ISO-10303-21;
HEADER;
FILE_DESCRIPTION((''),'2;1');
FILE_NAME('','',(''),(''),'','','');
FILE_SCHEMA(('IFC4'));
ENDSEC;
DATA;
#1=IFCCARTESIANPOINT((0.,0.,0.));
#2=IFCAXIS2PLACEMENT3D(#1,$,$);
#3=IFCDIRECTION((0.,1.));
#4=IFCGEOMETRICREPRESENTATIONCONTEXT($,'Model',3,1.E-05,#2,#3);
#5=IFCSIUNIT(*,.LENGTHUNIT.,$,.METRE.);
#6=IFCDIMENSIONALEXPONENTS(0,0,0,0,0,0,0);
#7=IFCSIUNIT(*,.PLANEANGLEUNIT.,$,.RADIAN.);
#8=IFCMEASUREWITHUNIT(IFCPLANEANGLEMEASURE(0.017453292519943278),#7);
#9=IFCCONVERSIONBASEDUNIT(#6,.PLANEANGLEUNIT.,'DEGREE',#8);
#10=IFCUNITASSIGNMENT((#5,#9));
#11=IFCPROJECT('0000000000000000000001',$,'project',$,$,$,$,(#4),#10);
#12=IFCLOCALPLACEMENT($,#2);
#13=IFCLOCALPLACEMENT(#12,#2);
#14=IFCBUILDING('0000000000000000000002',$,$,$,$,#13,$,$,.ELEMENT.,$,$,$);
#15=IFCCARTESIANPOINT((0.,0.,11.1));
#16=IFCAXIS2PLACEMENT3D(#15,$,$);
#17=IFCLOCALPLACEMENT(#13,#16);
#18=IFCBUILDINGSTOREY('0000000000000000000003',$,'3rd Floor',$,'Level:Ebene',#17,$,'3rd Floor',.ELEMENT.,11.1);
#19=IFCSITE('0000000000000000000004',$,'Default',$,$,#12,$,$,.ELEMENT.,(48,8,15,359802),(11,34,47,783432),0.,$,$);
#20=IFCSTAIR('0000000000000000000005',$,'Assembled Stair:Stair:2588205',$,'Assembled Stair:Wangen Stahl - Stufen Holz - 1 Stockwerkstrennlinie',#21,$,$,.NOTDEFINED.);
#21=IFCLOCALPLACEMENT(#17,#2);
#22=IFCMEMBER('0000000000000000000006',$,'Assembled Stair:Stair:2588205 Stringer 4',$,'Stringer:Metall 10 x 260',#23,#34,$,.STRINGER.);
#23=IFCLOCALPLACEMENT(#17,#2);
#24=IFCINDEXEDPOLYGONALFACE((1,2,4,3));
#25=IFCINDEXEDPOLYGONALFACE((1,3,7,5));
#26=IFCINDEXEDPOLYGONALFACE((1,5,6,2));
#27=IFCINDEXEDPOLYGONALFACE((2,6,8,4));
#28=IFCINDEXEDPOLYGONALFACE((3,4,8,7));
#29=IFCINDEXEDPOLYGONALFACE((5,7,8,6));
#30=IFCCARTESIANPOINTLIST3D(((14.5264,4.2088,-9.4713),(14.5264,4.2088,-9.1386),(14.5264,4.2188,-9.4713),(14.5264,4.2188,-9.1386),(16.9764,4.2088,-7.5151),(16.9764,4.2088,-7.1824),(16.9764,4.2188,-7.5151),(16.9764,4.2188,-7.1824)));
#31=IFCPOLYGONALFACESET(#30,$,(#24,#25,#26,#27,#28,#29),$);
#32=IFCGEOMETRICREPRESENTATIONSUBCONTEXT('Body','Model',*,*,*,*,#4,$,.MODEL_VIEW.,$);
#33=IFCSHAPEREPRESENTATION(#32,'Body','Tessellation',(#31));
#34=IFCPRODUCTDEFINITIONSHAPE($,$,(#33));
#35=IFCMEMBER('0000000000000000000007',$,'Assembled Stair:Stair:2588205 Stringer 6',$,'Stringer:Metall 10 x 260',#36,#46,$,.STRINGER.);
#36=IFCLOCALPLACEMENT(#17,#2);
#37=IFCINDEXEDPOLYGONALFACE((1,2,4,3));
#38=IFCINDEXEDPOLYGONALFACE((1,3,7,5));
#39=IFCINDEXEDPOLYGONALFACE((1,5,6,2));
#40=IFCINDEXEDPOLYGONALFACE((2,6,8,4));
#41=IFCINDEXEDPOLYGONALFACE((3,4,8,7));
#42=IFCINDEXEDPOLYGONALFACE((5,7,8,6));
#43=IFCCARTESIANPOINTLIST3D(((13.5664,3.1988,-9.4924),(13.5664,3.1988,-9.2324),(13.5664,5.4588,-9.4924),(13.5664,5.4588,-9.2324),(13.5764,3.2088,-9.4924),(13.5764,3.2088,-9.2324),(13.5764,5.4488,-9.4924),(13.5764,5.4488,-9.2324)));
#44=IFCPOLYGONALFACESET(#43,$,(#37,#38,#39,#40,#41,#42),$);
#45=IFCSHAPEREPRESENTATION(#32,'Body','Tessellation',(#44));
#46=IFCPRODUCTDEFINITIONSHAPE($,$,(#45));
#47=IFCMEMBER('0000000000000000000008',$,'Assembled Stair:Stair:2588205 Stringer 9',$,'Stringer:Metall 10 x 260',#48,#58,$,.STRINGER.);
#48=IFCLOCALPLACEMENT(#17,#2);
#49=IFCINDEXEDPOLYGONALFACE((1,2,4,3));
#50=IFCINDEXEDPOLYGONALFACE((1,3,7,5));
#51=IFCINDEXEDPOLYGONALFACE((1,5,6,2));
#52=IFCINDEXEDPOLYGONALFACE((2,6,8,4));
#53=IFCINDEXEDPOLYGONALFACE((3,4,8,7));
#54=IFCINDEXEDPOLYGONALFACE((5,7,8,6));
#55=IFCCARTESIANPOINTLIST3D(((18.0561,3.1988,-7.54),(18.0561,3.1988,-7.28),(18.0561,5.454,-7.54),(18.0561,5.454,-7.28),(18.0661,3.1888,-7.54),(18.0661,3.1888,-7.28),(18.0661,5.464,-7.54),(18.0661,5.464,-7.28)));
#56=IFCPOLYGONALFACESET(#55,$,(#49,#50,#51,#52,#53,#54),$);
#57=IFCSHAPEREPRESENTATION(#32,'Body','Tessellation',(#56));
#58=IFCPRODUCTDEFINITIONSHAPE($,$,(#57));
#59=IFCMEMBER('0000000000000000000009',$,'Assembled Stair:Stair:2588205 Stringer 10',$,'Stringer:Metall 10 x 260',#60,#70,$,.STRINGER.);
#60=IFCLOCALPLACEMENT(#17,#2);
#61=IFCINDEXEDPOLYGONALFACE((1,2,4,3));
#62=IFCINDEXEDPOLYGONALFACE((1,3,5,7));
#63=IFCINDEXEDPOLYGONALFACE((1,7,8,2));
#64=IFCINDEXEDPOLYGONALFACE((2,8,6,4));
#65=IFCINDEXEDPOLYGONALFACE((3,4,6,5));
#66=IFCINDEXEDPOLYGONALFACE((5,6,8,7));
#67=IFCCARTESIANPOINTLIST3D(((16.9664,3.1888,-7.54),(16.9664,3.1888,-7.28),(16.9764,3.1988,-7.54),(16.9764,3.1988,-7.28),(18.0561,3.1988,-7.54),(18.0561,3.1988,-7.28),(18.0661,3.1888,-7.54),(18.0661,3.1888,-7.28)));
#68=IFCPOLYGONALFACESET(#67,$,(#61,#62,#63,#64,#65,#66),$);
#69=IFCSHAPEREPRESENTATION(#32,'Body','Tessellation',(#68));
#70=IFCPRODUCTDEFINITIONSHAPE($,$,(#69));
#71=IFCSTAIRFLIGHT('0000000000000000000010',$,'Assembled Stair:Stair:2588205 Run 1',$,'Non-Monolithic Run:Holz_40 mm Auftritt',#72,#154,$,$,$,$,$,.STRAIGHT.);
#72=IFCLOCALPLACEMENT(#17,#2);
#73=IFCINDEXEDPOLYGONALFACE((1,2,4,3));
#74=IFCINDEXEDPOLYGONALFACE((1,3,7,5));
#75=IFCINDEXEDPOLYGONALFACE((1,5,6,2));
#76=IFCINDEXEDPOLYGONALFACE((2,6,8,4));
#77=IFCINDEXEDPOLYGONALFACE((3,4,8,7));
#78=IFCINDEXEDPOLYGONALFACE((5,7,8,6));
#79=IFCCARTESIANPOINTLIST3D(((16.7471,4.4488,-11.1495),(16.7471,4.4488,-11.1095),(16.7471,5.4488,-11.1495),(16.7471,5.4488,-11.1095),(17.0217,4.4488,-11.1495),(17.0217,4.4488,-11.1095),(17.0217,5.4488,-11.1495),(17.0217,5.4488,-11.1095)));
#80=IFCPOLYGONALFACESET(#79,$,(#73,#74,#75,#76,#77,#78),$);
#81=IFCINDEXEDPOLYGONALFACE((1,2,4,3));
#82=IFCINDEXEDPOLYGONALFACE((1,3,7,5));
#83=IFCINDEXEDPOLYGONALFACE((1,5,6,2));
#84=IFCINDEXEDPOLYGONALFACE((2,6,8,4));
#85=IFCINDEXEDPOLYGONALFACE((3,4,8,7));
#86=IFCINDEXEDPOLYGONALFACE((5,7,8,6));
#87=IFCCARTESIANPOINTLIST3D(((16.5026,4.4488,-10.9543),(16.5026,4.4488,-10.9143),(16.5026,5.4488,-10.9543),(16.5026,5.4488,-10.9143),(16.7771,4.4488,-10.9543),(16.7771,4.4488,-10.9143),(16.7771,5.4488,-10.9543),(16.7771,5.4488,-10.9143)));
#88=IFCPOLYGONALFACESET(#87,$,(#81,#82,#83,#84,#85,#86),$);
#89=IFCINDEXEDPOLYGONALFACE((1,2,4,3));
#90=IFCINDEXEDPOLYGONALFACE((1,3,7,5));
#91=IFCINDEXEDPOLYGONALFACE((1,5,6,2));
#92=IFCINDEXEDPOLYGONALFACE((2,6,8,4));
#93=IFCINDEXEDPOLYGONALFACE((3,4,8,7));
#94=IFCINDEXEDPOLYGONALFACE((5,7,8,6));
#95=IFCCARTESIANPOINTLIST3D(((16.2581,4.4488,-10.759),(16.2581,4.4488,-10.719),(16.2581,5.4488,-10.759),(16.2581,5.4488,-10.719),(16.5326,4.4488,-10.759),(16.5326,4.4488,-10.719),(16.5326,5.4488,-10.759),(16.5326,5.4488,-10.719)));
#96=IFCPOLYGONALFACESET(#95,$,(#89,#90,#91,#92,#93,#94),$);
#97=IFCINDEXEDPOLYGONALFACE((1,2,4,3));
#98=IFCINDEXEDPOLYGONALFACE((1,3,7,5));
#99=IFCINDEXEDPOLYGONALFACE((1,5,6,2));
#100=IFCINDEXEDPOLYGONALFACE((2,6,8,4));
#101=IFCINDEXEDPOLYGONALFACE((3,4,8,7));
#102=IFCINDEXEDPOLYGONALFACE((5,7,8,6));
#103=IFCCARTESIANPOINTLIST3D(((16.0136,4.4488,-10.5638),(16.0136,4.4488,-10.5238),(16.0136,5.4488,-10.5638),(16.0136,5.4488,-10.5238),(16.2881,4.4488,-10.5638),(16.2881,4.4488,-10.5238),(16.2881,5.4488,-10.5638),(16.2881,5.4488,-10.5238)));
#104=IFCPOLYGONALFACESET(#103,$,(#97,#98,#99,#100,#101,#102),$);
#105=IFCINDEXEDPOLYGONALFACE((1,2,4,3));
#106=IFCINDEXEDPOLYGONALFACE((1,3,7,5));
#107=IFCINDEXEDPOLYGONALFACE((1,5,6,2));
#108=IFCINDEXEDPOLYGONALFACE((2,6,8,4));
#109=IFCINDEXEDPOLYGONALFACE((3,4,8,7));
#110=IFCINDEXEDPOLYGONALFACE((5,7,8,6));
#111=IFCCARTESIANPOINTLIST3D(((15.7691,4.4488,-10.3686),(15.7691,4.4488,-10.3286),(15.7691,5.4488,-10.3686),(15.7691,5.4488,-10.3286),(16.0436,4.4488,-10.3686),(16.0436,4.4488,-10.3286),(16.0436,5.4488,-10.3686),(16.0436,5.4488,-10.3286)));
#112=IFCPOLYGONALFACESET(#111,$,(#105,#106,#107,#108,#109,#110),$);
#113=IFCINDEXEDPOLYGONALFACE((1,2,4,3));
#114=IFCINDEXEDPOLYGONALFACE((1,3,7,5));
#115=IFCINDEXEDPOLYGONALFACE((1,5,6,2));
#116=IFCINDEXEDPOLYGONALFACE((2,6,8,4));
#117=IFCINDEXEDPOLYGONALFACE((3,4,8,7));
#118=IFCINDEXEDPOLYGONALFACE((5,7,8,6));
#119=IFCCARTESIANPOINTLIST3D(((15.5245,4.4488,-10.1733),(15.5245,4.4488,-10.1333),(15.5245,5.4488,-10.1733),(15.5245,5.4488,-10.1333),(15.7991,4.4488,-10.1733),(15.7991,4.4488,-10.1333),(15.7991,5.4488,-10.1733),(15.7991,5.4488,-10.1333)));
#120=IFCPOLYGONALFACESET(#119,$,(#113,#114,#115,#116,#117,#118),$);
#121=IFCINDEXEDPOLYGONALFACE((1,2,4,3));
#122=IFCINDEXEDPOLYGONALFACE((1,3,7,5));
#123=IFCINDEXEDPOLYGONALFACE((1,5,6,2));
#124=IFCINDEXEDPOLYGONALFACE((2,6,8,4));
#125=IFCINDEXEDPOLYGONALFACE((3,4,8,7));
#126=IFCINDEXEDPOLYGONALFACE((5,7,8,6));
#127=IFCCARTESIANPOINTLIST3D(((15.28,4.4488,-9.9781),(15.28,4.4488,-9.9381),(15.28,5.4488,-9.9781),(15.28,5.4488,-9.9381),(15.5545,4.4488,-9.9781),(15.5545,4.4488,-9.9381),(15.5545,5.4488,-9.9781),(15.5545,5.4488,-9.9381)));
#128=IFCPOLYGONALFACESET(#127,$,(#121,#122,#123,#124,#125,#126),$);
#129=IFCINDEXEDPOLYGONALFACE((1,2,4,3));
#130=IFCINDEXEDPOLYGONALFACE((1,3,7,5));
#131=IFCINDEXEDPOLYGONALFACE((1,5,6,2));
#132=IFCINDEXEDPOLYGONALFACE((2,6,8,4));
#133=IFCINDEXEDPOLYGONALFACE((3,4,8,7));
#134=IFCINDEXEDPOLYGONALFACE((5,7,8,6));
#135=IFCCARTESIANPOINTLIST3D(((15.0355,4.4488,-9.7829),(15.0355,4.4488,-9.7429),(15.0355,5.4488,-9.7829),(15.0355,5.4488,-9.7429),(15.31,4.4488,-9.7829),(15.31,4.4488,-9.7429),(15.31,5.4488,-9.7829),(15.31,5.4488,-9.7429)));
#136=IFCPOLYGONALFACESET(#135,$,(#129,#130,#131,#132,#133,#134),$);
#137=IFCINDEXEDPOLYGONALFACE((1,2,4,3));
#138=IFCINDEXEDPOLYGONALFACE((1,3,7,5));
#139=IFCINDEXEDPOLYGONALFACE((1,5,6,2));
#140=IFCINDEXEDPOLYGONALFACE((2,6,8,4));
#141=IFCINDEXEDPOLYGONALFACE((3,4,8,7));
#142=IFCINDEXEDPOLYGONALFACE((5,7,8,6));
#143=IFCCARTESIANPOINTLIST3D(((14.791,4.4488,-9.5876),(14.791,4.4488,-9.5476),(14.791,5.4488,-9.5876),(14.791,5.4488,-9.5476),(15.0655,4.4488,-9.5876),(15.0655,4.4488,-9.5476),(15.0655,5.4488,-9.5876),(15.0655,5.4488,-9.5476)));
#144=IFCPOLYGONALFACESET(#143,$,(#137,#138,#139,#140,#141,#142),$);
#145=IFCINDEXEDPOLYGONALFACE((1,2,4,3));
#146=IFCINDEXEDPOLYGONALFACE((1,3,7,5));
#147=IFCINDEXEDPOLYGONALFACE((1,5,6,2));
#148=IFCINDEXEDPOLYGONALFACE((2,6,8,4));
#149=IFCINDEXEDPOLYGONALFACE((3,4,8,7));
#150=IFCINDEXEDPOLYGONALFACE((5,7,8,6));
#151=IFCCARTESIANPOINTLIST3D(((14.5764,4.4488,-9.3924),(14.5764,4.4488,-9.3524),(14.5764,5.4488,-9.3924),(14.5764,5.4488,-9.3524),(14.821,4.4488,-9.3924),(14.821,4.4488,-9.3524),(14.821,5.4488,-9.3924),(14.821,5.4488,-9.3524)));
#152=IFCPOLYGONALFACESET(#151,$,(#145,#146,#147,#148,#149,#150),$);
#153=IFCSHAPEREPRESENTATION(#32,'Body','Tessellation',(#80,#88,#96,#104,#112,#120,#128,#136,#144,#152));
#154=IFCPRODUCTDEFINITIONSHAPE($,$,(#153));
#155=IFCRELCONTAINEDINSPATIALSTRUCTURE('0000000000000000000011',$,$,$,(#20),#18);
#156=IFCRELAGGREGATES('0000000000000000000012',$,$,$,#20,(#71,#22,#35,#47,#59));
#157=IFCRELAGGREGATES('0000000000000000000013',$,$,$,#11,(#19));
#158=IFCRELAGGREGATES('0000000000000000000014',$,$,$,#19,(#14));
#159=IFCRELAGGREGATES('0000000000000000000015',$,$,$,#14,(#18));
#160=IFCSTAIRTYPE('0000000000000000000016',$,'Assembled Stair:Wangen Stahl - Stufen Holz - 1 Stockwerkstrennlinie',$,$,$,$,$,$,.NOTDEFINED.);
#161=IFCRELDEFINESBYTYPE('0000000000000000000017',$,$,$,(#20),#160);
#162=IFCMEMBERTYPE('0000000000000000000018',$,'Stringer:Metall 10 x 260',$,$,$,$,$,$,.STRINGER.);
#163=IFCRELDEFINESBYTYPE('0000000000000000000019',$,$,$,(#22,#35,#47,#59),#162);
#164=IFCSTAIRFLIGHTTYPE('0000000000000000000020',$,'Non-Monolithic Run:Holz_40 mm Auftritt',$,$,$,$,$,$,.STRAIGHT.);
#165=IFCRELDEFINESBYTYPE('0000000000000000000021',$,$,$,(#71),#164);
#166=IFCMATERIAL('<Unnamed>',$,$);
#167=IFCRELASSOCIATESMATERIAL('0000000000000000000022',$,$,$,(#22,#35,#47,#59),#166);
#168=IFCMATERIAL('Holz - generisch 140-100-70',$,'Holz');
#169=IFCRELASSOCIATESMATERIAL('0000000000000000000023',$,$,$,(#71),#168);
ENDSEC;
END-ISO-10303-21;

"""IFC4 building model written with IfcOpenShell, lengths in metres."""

from ifc_helpers import new_model, entity, si_unit, converted_unit, direction, frame, origin, place, context, subcontext, project, spatial, indexed_curve, outline, extrude, material, type_object, element, aggregate, save


model = new_model("IFC4")

# Units and contexts
model_context = context("Model", 3, precision=1e-05, world=origin(), true_north=direction((0.0, 1.0)))
body_context = subcontext(model_context, "Body", "Model", "MODEL_VIEW")
ifc_project = project(units=[si_unit("LENGTHUNIT", "METRE"), converted_unit("PLANEANGLEUNIT", "DEGREE", entity("IfcPlaneAngleMeasure", 0.017453292519943278), si_unit("PLANEANGLEUNIT", "RADIAN"), dimensions=[0, 0, 0, 0, 0, 0, 0])], contexts=[model_context])

# Site, building, storey
site_placement = place(None, origin())
site = spatial("IfcSite", under=ifc_project, at=site_placement, Name="Default", CompositionType="ELEMENT", RefLatitude=(48, 8, 15, 359802), RefLongitude=(11, 34, 47, 783432), RefElevation=0.0)
building_placement = place(site_placement, origin())
building = spatial("IfcBuilding", under=site, at=building_placement, CompositionType="ELEMENT")
storey_placement = place(building_placement, frame((0.0, 0.0, 11.1)))
storey = spatial("IfcBuildingStorey", under=building, at=storey_placement, Name="3rd Floor", ObjectType="Level:Ebene", LongName="3rd Floor", CompositionType="ELEMENT", Elevation=11.1)

# Stair, members
stair_type = type_object("IfcStairType", Name="Assembled Stair:Wangen Stahl - Stufen Holz - 1 Stockwerkstrennlinie", PredefinedType="NOTDEFINED")
stair_placement = place(storey_placement, origin())
stair = element("IfcStair", 1, at=stair_placement, inside=storey, type_object=stair_type, Name="Assembled Stair:Stair:2588205", ObjectType="Assembled Stair:Wangen Stahl - Stufen Holz - 1 Stockwerkstrennlinie", PredefinedType="NOTDEFINED")
ifc_material_1 = material(Name="<Unnamed>")
member_type = type_object("IfcMemberType", Name="Stringer:Metall 10 x 260", PredefinedType="STRINGER")
member_1_placement = place(stair_placement, origin())
member_1 = element("IfcMember", 2, at=member_1_placement, type_object=member_type, material=ifc_material_1, Name="Assembled Stair:Stair:2588205 Stringer 4", ObjectType="Stringer:Metall 10 x 260", PredefinedType="STRINGER", context=body_context, shape_type="SweptSolid", body=[
    extrude(outline(indexed_curve([(-1.4638, -0.13), (1.6714, -0.13), (1.4638, 0.13), (-1.6714, 0.13), (-1.4638, -0.13)], self_intersect=False)), frame((15.7514, 4.2088, -8.3269), z_axis=(0.0, 1.0, 0.0), x_axis=(0.781462, 0.0, 0.623952)), (0.0, 0.0, 1.0), 0.01),
])
member_2_placement = place(stair_placement, origin())
member_2 = element("IfcMember", 3, at=member_2_placement, type_object=member_type, material=ifc_material_1, Name="Assembled Stair:Stair:2588205 Stringer 6", ObjectType="Stringer:Metall 10 x 260", PredefinedType="STRINGER", context=body_context, shape_type="SweptSolid", body=[
    extrude(outline(indexed_curve([(-1.13, -0.005), (1.13, -0.005), (1.12, 0.005), (-1.12, 0.005), (-1.13, -0.005)], self_intersect=False)), frame((13.5714, 4.3288, -9.4924), z_axis=(0.0, 0.0, 1.0), x_axis=(0.0, -1.0, 0.0)), (0.0, 0.0, 1.0), 0.26),
])
member_3_placement = place(stair_placement, origin())
member_3 = element("IfcMember", 4, at=member_3_placement, type_object=member_type, material=ifc_material_1, Name="Assembled Stair:Stair:2588205 Stringer 9", ObjectType="Stringer:Metall 10 x 260", PredefinedType="STRINGER", context=body_context, shape_type="SweptSolid", body=[
    extrude(outline(indexed_curve([(-1.1376, -0.005), (1.1376, -0.005), (1.1276, 0.005), (-1.1276, 0.005), (-1.1376, -0.005)], self_intersect=False)), frame((18.0611, 4.3264, -7.54), z_axis=(0.0, 0.0, 1.0), x_axis=(0.0, 1.0, 0.0)), (0.0, 0.0, 1.0), 0.26),
])
member_4_placement = place(stair_placement, origin())
member_4 = element("IfcMember", 5, at=member_4_placement, type_object=member_type, material=ifc_material_1, Name="Assembled Stair:Stair:2588205 Stringer 10", ObjectType="Stringer:Metall 10 x 260", PredefinedType="STRINGER", context=body_context, shape_type="SweptSolid", body=[
    extrude(outline(indexed_curve([(-0.5498, -0.005), (0.5498, -0.005), (0.5398, 0.005), (-0.5398, 0.005), (-0.5498, -0.005)], self_intersect=False)), frame((17.5163, 3.1938, -7.54)), (0.0, 0.0, 1.0), 0.26),
])

# Shared definitions
ifc_material_2 = material(Name="Holz - generisch 140-100-70", Category="Holz")

# Stair flight
stair_flight_type = type_object("IfcStairFlightType", Name="Non-Monolithic Run:Holz_40 mm Auftritt", PredefinedType="STRAIGHT")
stair_flight_1_placement = place(stair_placement, origin())
stair_flight_1 = element("IfcStairFlight", 6, at=stair_flight_1_placement, type_object=stair_flight_type, material=ifc_material_2, Name="Assembled Stair:Stair:2588205 Run 1", ObjectType="Non-Monolithic Run:Holz_40 mm Auftritt", PredefinedType="STRAIGHT", context=body_context, shape_type="SweptSolid", body=[
    extrude(outline(indexed_curve([(-0.1373, -0.5), (0.1373, -0.5), (0.1373, 0.5), (-0.1373, 0.5), (-0.1373, -0.5)], self_intersect=False)), frame((16.8844, 4.9488, -11.1495)), (0.0, 0.0, 1.0), 0.04),
    extrude(outline(indexed_curve([(-0.1373, -0.5), (0.1373, -0.5), (0.1373, 0.5), (-0.1373, 0.5), (-0.1373, -0.5)], self_intersect=False)), frame((16.6399, 4.9488, -10.9543)), (0.0, 0.0, 1.0), 0.04),
    extrude(outline(indexed_curve([(-0.1373, -0.5), (0.1373, -0.5), (0.1373, 0.5), (-0.1373, 0.5), (-0.1373, -0.5)], self_intersect=False)), frame((16.3954, 4.9488, -10.759)), (0.0, 0.0, 1.0), 0.04),
    extrude(outline(indexed_curve([(-0.1373, -0.5), (0.1373, -0.5), (0.1373, 0.5), (-0.1373, 0.5), (-0.1373, -0.5)], self_intersect=False)), frame((16.1508, 4.9488, -10.5638)), (0.0, 0.0, 1.0), 0.04),
    extrude(outline(indexed_curve([(-0.1373, -0.5), (0.1373, -0.5), (0.1373, 0.5), (-0.1373, 0.5), (-0.1373, -0.5)], self_intersect=False)), frame((15.9063, 4.9488, -10.3686)), (0.0, 0.0, 1.0), 0.04),
    extrude(outline(indexed_curve([(-0.1373, -0.5), (0.1373, -0.5), (0.1373, 0.5), (-0.1373, 0.5), (-0.1373, -0.5)], self_intersect=False)), frame((15.6618, 4.9488, -10.1733)), (0.0, 0.0, 1.0), 0.04),
    extrude(outline(indexed_curve([(-0.1373, -0.5), (0.1373, -0.5), (0.1373, 0.5), (-0.1373, 0.5), (-0.1373, -0.5)], self_intersect=False)), frame((15.4173, 4.9488, -9.9781)), (0.0, 0.0, 1.0), 0.04),
    extrude(outline(indexed_curve([(-0.1373, -0.5), (0.1373, -0.5), (0.1373, 0.5), (-0.1373, 0.5), (-0.1373, -0.5)], self_intersect=False)), frame((15.1727, 4.9488, -9.7829)), (0.0, 0.0, 1.0), 0.04),
    extrude(outline(indexed_curve([(-0.1373, -0.5), (0.1373, -0.5), (0.1373, 0.5), (-0.1373, 0.5), (-0.1373, -0.5)], self_intersect=False)), frame((14.9282, 4.9488, -9.5876)), (0.0, 0.0, 1.0), 0.04),
    extrude(outline(indexed_curve([(-0.1223, -0.5), (0.1223, -0.5), (0.1223, 0.5), (-0.1223, 0.5), (-0.1223, -0.5)], self_intersect=False)), frame((14.6987, 4.9488, -9.3924)), (0.0, 0.0, 1.0), 0.04),
])
aggregate(stair, [stair_flight_1, member_1, member_2, member_3, member_4])

save(model, "model.ifc")
